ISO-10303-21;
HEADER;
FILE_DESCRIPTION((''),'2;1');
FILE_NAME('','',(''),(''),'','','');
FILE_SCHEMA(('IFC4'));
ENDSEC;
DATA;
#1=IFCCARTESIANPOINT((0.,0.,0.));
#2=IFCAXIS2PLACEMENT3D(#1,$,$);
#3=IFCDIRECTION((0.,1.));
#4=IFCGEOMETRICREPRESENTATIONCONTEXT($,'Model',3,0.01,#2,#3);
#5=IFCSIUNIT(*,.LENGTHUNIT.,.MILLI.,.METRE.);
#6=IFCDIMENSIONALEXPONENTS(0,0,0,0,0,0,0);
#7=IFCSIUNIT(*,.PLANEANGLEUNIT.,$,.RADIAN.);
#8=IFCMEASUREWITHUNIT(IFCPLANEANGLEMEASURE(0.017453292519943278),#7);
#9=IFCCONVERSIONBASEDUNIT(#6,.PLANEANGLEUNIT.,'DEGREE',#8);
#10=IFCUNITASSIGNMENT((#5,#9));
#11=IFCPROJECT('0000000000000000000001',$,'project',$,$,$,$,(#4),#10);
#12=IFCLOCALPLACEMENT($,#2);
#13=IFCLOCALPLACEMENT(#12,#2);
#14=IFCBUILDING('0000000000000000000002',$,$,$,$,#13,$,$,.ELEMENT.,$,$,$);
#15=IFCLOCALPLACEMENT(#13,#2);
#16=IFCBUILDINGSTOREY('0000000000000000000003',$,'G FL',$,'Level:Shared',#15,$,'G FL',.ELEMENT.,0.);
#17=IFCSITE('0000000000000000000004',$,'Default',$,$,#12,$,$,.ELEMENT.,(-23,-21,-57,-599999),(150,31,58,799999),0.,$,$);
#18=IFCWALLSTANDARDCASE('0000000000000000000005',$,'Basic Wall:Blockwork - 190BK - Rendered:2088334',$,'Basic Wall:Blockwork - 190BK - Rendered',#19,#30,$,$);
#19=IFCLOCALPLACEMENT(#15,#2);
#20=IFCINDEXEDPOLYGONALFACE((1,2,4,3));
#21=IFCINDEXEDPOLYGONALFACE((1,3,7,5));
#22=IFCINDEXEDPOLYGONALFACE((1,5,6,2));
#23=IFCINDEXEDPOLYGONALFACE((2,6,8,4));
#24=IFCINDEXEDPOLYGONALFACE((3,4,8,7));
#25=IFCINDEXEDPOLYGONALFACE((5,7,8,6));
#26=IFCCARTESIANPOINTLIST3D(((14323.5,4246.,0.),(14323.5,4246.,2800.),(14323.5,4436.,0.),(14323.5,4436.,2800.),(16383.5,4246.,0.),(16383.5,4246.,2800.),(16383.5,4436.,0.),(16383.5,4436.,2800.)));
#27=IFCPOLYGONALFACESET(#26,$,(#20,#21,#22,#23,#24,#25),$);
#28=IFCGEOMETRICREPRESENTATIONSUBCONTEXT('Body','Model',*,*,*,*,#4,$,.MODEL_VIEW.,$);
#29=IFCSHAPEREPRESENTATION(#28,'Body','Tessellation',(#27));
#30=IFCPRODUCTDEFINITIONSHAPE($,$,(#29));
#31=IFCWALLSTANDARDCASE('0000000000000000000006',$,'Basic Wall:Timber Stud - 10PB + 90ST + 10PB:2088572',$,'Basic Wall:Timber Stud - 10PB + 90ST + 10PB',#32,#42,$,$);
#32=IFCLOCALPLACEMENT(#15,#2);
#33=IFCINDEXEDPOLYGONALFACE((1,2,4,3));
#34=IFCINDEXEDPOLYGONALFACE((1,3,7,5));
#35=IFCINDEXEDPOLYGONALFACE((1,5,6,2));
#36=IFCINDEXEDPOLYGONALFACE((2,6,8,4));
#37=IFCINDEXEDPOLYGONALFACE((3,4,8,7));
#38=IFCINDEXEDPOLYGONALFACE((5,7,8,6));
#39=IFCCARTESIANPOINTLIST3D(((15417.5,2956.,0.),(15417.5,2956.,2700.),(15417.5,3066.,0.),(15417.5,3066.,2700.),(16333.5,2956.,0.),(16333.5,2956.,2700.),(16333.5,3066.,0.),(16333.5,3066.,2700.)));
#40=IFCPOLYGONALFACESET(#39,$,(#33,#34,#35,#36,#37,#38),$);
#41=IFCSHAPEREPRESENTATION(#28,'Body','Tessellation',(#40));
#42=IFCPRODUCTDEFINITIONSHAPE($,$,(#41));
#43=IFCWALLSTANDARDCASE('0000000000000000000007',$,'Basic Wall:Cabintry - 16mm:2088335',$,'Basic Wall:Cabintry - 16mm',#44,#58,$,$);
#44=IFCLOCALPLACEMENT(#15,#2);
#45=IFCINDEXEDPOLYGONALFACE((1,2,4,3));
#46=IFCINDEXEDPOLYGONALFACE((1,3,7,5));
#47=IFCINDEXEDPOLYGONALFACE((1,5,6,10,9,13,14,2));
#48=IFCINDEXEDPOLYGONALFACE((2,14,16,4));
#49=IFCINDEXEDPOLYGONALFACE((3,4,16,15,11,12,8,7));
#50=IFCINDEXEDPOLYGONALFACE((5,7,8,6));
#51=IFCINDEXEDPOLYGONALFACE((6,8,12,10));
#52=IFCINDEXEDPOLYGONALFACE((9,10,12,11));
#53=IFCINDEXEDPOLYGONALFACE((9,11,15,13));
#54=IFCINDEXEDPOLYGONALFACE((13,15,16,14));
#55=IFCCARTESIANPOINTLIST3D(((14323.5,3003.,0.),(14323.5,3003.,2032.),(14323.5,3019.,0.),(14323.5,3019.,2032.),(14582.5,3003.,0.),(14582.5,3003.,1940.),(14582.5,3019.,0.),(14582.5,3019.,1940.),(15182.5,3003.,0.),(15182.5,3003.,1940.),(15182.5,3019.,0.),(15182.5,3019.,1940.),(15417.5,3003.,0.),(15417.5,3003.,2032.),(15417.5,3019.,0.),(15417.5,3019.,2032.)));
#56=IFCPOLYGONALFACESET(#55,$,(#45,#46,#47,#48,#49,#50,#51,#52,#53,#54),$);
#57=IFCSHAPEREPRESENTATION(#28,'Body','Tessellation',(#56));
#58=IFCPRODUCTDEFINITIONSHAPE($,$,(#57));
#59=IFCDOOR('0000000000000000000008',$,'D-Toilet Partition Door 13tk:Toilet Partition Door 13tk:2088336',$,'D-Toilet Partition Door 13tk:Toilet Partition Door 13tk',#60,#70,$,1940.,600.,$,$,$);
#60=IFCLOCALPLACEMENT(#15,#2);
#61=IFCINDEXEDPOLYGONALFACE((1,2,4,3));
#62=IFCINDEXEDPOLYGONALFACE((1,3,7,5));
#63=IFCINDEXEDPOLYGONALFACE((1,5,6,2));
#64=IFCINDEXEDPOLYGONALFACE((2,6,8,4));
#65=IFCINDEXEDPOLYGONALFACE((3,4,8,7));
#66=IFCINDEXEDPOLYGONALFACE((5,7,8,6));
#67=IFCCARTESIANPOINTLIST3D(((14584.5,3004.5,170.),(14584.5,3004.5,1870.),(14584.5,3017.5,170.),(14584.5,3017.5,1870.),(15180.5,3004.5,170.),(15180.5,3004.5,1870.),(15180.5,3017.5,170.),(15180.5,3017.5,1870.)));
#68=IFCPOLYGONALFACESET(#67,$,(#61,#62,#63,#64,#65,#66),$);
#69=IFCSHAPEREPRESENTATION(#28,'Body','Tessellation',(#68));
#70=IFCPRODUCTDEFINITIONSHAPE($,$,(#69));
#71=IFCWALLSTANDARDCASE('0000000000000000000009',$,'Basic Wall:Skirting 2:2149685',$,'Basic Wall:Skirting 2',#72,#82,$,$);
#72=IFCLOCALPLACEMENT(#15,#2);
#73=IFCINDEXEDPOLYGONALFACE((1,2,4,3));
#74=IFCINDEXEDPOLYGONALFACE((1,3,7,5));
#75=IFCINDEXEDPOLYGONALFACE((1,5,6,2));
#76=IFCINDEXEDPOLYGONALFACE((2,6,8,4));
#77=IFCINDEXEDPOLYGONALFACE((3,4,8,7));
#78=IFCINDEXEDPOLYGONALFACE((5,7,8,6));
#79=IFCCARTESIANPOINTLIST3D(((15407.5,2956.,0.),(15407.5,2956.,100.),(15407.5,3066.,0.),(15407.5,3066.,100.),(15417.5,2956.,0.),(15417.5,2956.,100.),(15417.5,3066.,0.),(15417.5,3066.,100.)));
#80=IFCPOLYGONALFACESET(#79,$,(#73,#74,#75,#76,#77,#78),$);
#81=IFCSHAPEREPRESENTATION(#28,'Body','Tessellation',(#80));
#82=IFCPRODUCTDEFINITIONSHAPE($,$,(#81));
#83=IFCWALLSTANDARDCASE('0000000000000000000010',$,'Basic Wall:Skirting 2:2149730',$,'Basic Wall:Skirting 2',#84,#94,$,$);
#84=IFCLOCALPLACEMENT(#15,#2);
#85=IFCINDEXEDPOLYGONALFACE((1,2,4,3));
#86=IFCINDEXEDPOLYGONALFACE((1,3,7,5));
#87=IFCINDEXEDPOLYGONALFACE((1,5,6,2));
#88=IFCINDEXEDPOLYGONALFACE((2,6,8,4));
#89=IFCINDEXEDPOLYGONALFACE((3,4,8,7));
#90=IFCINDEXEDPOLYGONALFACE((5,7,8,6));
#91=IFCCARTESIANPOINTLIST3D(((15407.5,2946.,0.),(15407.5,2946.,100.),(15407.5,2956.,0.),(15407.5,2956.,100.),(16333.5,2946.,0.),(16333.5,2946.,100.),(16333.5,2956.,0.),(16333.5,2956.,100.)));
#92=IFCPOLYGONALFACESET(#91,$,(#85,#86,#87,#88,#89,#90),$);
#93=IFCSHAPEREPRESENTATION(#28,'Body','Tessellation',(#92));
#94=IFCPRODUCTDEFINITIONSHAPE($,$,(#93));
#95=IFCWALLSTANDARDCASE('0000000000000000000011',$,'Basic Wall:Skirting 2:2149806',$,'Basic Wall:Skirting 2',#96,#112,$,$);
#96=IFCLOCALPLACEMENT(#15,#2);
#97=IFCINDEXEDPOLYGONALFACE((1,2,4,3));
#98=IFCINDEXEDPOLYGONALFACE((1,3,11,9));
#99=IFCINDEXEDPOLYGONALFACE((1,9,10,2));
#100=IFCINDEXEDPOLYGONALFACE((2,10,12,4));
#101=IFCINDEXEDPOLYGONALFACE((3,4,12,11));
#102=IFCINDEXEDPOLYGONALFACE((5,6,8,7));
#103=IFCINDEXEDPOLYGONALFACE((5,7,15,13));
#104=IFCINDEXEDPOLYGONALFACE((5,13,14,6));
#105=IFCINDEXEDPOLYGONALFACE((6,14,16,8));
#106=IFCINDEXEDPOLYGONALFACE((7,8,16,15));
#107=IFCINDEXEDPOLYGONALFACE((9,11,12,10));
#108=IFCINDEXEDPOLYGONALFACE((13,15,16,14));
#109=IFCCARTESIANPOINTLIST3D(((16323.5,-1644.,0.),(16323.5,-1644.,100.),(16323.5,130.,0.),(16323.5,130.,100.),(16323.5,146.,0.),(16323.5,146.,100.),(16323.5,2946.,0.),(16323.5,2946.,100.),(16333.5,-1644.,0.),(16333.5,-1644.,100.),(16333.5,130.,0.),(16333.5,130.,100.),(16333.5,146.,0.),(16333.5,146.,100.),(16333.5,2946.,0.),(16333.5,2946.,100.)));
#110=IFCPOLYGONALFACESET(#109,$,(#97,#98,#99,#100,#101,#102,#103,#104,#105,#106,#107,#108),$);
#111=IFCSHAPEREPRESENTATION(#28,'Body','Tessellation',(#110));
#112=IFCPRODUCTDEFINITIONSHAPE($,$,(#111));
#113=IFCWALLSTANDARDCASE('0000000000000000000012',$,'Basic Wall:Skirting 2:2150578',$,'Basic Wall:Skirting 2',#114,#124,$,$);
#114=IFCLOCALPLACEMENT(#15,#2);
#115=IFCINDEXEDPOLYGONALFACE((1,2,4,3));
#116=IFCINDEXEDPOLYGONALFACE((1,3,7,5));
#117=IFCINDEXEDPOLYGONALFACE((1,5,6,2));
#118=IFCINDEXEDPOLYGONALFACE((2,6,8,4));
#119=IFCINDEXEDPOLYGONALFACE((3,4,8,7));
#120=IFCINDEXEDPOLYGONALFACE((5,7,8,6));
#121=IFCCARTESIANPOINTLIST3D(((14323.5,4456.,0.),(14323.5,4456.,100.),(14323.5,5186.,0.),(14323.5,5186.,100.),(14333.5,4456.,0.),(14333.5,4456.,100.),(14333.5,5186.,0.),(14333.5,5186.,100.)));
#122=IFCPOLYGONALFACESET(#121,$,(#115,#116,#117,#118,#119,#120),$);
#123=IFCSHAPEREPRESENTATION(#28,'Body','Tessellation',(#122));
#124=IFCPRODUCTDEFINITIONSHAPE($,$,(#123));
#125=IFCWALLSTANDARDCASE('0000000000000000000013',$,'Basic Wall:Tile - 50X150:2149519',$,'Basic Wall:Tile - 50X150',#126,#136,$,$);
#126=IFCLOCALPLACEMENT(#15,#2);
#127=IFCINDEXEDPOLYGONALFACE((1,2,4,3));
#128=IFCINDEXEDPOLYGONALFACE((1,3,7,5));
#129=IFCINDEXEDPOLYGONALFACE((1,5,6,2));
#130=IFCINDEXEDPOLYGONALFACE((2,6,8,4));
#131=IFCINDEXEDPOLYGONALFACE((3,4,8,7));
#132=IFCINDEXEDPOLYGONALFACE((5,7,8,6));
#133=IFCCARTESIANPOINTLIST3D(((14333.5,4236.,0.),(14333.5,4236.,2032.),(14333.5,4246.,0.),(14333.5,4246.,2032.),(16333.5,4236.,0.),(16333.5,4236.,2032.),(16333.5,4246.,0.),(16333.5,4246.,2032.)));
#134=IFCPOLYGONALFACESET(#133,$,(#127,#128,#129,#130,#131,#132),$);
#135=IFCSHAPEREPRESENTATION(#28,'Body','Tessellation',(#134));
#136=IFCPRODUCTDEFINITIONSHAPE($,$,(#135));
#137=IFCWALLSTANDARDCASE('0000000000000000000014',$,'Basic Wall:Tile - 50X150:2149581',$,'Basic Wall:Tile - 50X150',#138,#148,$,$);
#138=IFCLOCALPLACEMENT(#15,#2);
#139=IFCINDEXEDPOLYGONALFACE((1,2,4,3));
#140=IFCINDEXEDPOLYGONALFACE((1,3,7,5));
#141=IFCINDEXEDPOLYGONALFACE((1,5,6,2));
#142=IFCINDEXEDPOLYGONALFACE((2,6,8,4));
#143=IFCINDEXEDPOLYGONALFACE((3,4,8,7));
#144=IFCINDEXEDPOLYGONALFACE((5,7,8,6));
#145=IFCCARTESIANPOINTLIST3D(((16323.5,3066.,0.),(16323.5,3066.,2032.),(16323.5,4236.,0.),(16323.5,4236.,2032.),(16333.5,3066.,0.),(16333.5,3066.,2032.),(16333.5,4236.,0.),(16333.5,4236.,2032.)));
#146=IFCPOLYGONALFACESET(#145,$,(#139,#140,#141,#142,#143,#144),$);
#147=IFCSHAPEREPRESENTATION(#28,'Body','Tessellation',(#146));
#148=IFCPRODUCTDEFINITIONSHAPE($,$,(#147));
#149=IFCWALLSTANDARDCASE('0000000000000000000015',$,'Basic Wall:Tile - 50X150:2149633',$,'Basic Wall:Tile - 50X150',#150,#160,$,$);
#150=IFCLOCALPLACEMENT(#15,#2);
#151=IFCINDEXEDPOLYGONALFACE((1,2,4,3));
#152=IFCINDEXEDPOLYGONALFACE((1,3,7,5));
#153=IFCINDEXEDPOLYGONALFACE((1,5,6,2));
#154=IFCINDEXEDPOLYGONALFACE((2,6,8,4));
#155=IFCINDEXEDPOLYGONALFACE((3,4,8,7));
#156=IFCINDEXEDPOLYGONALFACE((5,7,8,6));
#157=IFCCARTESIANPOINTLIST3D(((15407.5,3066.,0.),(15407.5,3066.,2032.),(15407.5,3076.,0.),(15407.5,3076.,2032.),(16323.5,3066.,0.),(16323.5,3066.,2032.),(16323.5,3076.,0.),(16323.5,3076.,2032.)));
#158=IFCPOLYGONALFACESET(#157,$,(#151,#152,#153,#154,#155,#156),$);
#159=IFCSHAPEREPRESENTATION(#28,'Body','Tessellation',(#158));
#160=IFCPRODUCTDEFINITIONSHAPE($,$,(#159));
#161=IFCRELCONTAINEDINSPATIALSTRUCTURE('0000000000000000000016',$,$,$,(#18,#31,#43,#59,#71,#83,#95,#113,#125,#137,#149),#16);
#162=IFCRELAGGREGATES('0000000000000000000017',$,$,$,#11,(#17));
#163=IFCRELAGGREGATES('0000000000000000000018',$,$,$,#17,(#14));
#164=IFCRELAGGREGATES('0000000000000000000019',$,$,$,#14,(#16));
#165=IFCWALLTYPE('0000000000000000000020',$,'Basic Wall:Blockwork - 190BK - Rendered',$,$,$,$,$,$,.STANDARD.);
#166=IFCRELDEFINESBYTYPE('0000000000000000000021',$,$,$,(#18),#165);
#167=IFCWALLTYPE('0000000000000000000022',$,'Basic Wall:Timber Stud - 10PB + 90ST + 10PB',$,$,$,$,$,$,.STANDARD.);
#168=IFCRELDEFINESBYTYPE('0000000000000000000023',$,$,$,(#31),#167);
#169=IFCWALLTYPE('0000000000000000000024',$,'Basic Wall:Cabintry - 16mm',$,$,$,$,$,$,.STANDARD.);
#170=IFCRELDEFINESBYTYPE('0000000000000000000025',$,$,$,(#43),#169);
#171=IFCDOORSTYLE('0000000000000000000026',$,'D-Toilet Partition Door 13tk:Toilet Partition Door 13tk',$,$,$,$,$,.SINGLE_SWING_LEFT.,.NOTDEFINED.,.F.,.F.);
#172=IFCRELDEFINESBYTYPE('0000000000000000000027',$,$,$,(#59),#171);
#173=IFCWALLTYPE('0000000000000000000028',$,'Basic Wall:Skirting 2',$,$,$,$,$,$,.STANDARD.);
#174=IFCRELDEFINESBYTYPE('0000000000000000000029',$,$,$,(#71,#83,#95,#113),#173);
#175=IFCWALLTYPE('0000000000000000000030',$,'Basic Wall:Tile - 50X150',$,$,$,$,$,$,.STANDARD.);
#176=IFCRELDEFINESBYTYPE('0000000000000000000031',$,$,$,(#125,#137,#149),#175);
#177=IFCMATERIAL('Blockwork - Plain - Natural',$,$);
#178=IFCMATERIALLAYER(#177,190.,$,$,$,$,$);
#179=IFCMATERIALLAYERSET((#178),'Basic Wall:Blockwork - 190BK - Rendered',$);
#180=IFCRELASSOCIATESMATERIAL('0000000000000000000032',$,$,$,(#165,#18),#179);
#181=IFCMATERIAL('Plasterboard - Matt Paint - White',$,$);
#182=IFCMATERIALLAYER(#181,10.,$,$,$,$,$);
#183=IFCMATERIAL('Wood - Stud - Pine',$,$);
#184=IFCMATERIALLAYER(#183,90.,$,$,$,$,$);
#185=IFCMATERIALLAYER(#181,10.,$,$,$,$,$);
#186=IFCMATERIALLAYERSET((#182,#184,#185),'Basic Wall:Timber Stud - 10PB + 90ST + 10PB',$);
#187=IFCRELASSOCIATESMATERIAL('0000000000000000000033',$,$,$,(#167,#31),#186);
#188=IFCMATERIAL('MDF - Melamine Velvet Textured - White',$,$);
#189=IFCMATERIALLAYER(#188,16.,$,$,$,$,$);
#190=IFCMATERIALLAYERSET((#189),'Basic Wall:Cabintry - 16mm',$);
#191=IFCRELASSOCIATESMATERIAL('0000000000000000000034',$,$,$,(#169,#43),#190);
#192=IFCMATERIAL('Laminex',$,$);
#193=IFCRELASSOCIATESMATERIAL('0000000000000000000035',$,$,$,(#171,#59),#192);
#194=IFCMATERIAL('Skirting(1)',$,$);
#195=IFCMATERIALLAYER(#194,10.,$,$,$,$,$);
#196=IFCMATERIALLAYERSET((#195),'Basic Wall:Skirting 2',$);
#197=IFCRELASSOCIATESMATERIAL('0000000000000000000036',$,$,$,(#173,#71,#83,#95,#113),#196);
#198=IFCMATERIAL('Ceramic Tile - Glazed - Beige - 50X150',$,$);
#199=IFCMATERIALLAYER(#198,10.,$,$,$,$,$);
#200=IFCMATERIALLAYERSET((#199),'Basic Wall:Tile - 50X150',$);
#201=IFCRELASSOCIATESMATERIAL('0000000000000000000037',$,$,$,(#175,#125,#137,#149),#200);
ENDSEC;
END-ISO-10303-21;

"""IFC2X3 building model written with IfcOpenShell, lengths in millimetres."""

from ifc_helpers import new_model, entity, si_unit, converted_unit, direction, frame, frame_2d, origin, place, context, subcontext, project, spatial, rectangle, extrude, source, transform, mapped, material, layer, layer_set, layer_usage, type_object, type_shapes, element, fill, save


model = new_model("IFC2X3")

# Units and contexts
model_context = context("Model", 3, precision=0.01, world=origin(), true_north=direction((0.0, 1.0)))
body_context = subcontext(model_context, "Body", "Model", "MODEL_VIEW")
ifc_project = project(units=[si_unit("LENGTHUNIT", "METRE", prefix="MILLI"), converted_unit("PLANEANGLEUNIT", "DEGREE", entity("IfcPlaneAngleMeasure", 0.017453292519943278), si_unit("PLANEANGLEUNIT", "RADIAN"), dimensions=[0, 0, 0, 0, 0, 0, 0])], contexts=[model_context])

# Site, building, storey
site_placement = place(None, origin())
site = spatial("IfcSite", under=ifc_project, at=site_placement, Name="Default", CompositionType="ELEMENT", RefLatitude=(-23, -21, -57, -599999), RefLongitude=(150, 31, 58, 799999), RefElevation=0.0)
building_placement = place(site_placement, origin())
building = spatial("IfcBuilding", under=site, at=building_placement, CompositionType="ELEMENT")
storey_placement = place(building_placement, origin())
storey = spatial("IfcBuildingStorey", under=building, at=storey_placement, Name="G FL", ObjectType="Level:Shared", LongName="G FL", CompositionType="ELEMENT", Elevation=0.0)

# Walls
ifc_material_1 = material(Name="Blockwork - Plain - Natural")
ifc_layer_1 = layer(ifc_material_1, 190.0)
ifc_layer_set_1 = layer_set([ifc_layer_1], Name="Basic Wall:Blockwork - 190BK - Rendered")
ifc_layer_usage_1 = layer_usage(ifc_layer_set_1, "AXIS2", "POSITIVE", -95.0)
wall_type_1 = type_object("IfcWallType", Name="Basic Wall:Blockwork - 190BK - Rendered", PredefinedType="STANDARD", material=ifc_layer_set_1)
wall_1_placement = place(storey_placement, frame((14323.5, 4341.0, 0.0)))
element("IfcWallStandardCase", 1, at=wall_1_placement, inside=storey, type_object=wall_type_1, material=ifc_layer_usage_1, Name="Basic Wall:Blockwork - 190BK - Rendered:2088334", ObjectType="Basic Wall:Blockwork - 190BK - Rendered", context=body_context, shape_type="SweptSolid", body=[
    extrude(rectangle(XDim=2060.0, YDim=190.0, at=frame_2d((1030.0, 0.0), x_axis=(-1.0, 0.0))), origin(), (0.0, 0.0, 1.0), 2800.0),
])
ifc_material_2 = material(Name="Plasterboard - Matt Paint - White")
ifc_layer_2 = layer(ifc_material_2, 10.0)
ifc_material_3 = material(Name="Wood - Stud - Pine")
ifc_layer_3 = layer(ifc_material_3, 90.0)
ifc_layer_4 = layer(ifc_material_2, 10.0)
ifc_layer_set_2 = layer_set([ifc_layer_2, ifc_layer_3, ifc_layer_4], Name="Basic Wall:Timber Stud - 10PB + 90ST + 10PB")
ifc_layer_usage_2 = layer_usage(ifc_layer_set_2, "AXIS2", "POSITIVE", -55.0)
wall_type_2 = type_object("IfcWallType", Name="Basic Wall:Timber Stud - 10PB + 90ST + 10PB", PredefinedType="STANDARD", material=ifc_layer_set_2)
wall_2_placement = place(storey_placement, frame((15417.5, 3011.0, 0.0)))
element("IfcWallStandardCase", 2, at=wall_2_placement, inside=storey, type_object=wall_type_2, material=ifc_layer_usage_2, Name="Basic Wall:Timber Stud - 10PB + 90ST + 10PB:2088572", ObjectType="Basic Wall:Timber Stud - 10PB + 90ST + 10PB", context=body_context, shape_type="SweptSolid", body=[
    extrude(rectangle(XDim=916.0, YDim=110.0, at=frame_2d((458.0, 0.0), x_axis=(-1.0, 0.0))), origin(), (0.0, 0.0, 1.0), 2700.0),
])

# Wall, opening, door
ifc_material_4 = material(Name="MDF - Melamine Velvet Textured - White")
ifc_layer_5 = layer(ifc_material_4, 16.0)
ifc_layer_set_3 = layer_set([ifc_layer_5], Name="Basic Wall:Cabintry - 16mm")
ifc_layer_usage_3 = layer_usage(ifc_layer_set_3, "AXIS2", "POSITIVE", -8.0)
wall_type_3 = type_object("IfcWallType", Name="Basic Wall:Cabintry - 16mm", PredefinedType="STANDARD", material=ifc_layer_set_3)
wall_3_placement = place(storey_placement, frame((14323.5, 3011.0, 0.0)))
wall_3 = element("IfcWallStandardCase", 3, at=wall_3_placement, inside=storey, type_object=wall_type_3, material=ifc_layer_usage_3, Name="Basic Wall:Cabintry - 16mm:2088335", ObjectType="Basic Wall:Cabintry - 16mm", context=body_context, shape_type="SweptSolid", body=[
    extrude(rectangle(XDim=1094.0, YDim=16.0, at=frame_2d((547.0, 0.0), x_axis=(1.0, 0.0))), origin(), (0.0, 0.0, 1.0), 2032.0),
])
opening_1_placement = place(wall_3_placement, frame((259.0, -8.0, 0.0)))
opening_1 = element("IfcOpeningElement", 4, at=opening_1_placement, cuts=wall_3, ObjectType="Opening", context=body_context, shape_type="SweptSolid", body=[
    extrude(rectangle(XDim=1940.0, YDim=600.0, at=frame_2d((970.0, 300.0), x_axis=(1.0, 0.0))), frame((0.0, 0.0, 0.0), z_axis=(0.0, 1.0, 0.0), x_axis=(0.0, 0.0, 1.0)), (0.0, 0.0, 1.0), 16.0),
])
ifc_material_5 = material(Name="Laminex")
door_style = type_object("IfcDoorStyle", Name="D-Toilet Partition Door 13tk:Toilet Partition Door 13tk", ConstructionType="NOTDEFINED", OperationType="SINGLE_SWING_LEFT", ParameterTakesPrecedence=False, Sizeable=False, material=ifc_material_5)
shared_shape_1 = source(origin(), body_context, "Body", "SweptSolid", [
    extrude(rectangle(XDim=13.0, YDim=596.0, at=frame_2d((0.0, 0.0), x_axis=(1.0, 0.0))), frame((300.0, 8.0, 170.0), z_axis=(0.0, 0.0, 1.0), x_axis=(0.0, 1.0, 0.0)), (0.0, 0.0, 1.0), 1700.0),
])
type_shapes(door_style, [shared_shape_1])
door_placement = place(opening_1_placement, origin())
door = element("IfcDoor", 5, at=door_placement, inside=storey, type_object=door_style, material=ifc_material_5, Name="D-Toilet Partition Door 13tk:Toilet Partition Door 13tk:2088336", ObjectType="D-Toilet Partition Door 13tk:Toilet Partition Door 13tk", OverallHeight=1940.0, OverallWidth=600.0, context=body_context, shape_type="MappedRepresentation", body=[
    mapped(shared_shape_1, transform((0.0, 0.0, 0.0), scale=1.0)),
])
fill(opening_1, door)

# Walls
ifc_material_6 = material(Name="Skirting(1)")
ifc_layer_6 = layer(ifc_material_6, 10.0)
ifc_layer_set_4 = layer_set([ifc_layer_6], Name="Basic Wall:Skirting 2")
ifc_layer_usage_4 = layer_usage(ifc_layer_set_4, "AXIS2", "NEGATIVE", 5.0)
wall_type_4 = type_object("IfcWallType", Name="Basic Wall:Skirting 2", PredefinedType="STANDARD", material=ifc_layer_set_4)
wall_4_placement = place(storey_placement, frame((15412.5, 3066.0, 0.0), z_axis=(0.0, 0.0, 1.0), x_axis=(0.0, -1.0, 0.0)))
element("IfcWallStandardCase", 6, at=wall_4_placement, inside=storey, type_object=wall_type_4, material=ifc_layer_usage_4, Name="Basic Wall:Skirting 2:2149685", ObjectType="Basic Wall:Skirting 2", context=body_context, shape_type="SweptSolid", body=[
    extrude(rectangle(XDim=110.0, YDim=10.0, at=frame_2d((55.0, 0.0), x_axis=(-1.0, 0.0))), origin(), (0.0, 0.0, 1.0), 100.0),
])
ifc_layer_usage_5 = layer_usage(ifc_layer_set_4, "AXIS2", "NEGATIVE", 5.0)
wall_5_placement = place(storey_placement, frame((15407.5, 2951.0, 0.0)))
element("IfcWallStandardCase", 7, at=wall_5_placement, inside=storey, type_object=wall_type_4, material=ifc_layer_usage_5, Name="Basic Wall:Skirting 2:2149730", ObjectType="Basic Wall:Skirting 2", context=body_context, shape_type="SweptSolid", body=[
    extrude(rectangle(XDim=926.0, YDim=10.0, at=frame_2d((463.0, 0.0), x_axis=(-1.0, 0.0))), origin(), (0.0, 0.0, 1.0), 100.0),
])

# Wall, opening
ifc_layer_usage_6 = layer_usage(ifc_layer_set_4, "AXIS2", "NEGATIVE", 5.0)
wall_6_placement = place(storey_placement, frame((16328.5, 2946.0, 0.0), z_axis=(0.0, 0.0, 1.0), x_axis=(0.0, -1.0, 0.0)))
wall_6 = element("IfcWallStandardCase", 8, at=wall_6_placement, inside=storey, type_object=wall_type_4, material=ifc_layer_usage_6, Name="Basic Wall:Skirting 2:2149806", ObjectType="Basic Wall:Skirting 2", context=body_context, shape_type="SweptSolid", body=[
    extrude(rectangle(XDim=4590.0, YDim=10.0, at=frame_2d((2295.0, 0.0), x_axis=(-1.0, 0.0))), origin(), (0.0, 0.0, 1.0), 100.0),
])
opening_2_placement = place(storey_placement, frame((16328.5, 2946.0, 0.0), z_axis=(0.0, 0.0, 1.0), x_axis=(0.0, -1.0, 0.0)))
element("IfcOpeningElement", 9, at=opening_2_placement, cuts=wall_6, ObjectType="Opening", context=body_context, shape_type="SweptSolid", body=[
    extrude(rectangle(XDim=100.0, YDim=10.0, at=frame_2d((0.0, 0.0), x_axis=(1.0, 0.0))), frame((2816.0, 0.0, 50.0), z_axis=(-1.0, 0.0, 0.0), x_axis=(0.0, 0.0, 1.0)), (0.0, 0.0, 1.0), 16.0),
])

# Walls
ifc_layer_usage_7 = layer_usage(ifc_layer_set_4, "AXIS2", "NEGATIVE", 5.0)
wall_7_placement = place(storey_placement, frame((14328.5, 4456.0, 0.0), z_axis=(0.0, 0.0, 1.0), x_axis=(0.0, 1.0, 0.0)))
element("IfcWallStandardCase", 10, at=wall_7_placement, inside=storey, type_object=wall_type_4, material=ifc_layer_usage_7, Name="Basic Wall:Skirting 2:2150578", ObjectType="Basic Wall:Skirting 2", context=body_context, shape_type="SweptSolid", body=[
    extrude(rectangle(XDim=730.0, YDim=10.0, at=frame_2d((365.0, 0.0), x_axis=(-1.0, 0.0))), origin(), (0.0, 0.0, 1.0), 100.0),
])
ifc_material_7 = material(Name="Ceramic Tile - Glazed - Beige - 50X150")
ifc_layer_7 = layer(ifc_material_7, 10.0)
ifc_layer_set_5 = layer_set([ifc_layer_7], Name="Basic Wall:Tile - 50X150")
ifc_layer_usage_8 = layer_usage(ifc_layer_set_5, "AXIS2", "NEGATIVE", 5.0)
wall_type_5 = type_object("IfcWallType", Name="Basic Wall:Tile - 50X150", PredefinedType="STANDARD", material=ifc_layer_set_5)
wall_8_placement = place(storey_placement, frame((14333.5, 4241.0, 0.0)))
element("IfcWallStandardCase", 11, at=wall_8_placement, inside=storey, type_object=wall_type_5, material=ifc_layer_usage_8, Name="Basic Wall:Tile - 50X150:2149519", ObjectType="Basic Wall:Tile - 50X150", context=body_context, shape_type="SweptSolid", body=[
    extrude(rectangle(XDim=2000.0, YDim=10.0, at=frame_2d((1000.0, 0.0), x_axis=(-1.0, 0.0))), origin(), (0.0, 0.0, 1.0), 2032.0),
])
ifc_layer_usage_9 = layer_usage(ifc_layer_set_5, "AXIS2", "NEGATIVE", 5.0)
wall_9_placement = place(storey_placement, frame((16328.5, 4236.0, 0.0), z_axis=(0.0, 0.0, 1.0), x_axis=(0.0, -1.0, 0.0)))
element("IfcWallStandardCase", 12, at=wall_9_placement, inside=storey, type_object=wall_type_5, material=ifc_layer_usage_9, Name="Basic Wall:Tile - 50X150:2149581", ObjectType="Basic Wall:Tile - 50X150", context=body_context, shape_type="SweptSolid", body=[
    extrude(rectangle(XDim=1170.0, YDim=10.0, at=frame_2d((585.0, 0.0), x_axis=(-1.0, 0.0))), origin(), (0.0, 0.0, 1.0), 2032.0),
])
ifc_layer_usage_10 = layer_usage(ifc_layer_set_5, "AXIS2", "NEGATIVE", 5.0)
wall_10_placement = place(storey_placement, frame((16323.5, 3071.0, 0.0), z_axis=(0.0, 0.0, 1.0), x_axis=(-1.0, 0.0, 0.0)))
element("IfcWallStandardCase", 13, at=wall_10_placement, inside=storey, type_object=wall_type_5, material=ifc_layer_usage_10, Name="Basic Wall:Tile - 50X150:2149633", ObjectType="Basic Wall:Tile - 50X150", context=body_context, shape_type="SweptSolid", body=[
    extrude(rectangle(XDim=916.0, YDim=10.0, at=frame_2d((458.0, 0.0), x_axis=(-1.0, 0.0))), origin(), (0.0, 0.0, 1.0), 2032.0),
])

save(model, "model.ifc")
